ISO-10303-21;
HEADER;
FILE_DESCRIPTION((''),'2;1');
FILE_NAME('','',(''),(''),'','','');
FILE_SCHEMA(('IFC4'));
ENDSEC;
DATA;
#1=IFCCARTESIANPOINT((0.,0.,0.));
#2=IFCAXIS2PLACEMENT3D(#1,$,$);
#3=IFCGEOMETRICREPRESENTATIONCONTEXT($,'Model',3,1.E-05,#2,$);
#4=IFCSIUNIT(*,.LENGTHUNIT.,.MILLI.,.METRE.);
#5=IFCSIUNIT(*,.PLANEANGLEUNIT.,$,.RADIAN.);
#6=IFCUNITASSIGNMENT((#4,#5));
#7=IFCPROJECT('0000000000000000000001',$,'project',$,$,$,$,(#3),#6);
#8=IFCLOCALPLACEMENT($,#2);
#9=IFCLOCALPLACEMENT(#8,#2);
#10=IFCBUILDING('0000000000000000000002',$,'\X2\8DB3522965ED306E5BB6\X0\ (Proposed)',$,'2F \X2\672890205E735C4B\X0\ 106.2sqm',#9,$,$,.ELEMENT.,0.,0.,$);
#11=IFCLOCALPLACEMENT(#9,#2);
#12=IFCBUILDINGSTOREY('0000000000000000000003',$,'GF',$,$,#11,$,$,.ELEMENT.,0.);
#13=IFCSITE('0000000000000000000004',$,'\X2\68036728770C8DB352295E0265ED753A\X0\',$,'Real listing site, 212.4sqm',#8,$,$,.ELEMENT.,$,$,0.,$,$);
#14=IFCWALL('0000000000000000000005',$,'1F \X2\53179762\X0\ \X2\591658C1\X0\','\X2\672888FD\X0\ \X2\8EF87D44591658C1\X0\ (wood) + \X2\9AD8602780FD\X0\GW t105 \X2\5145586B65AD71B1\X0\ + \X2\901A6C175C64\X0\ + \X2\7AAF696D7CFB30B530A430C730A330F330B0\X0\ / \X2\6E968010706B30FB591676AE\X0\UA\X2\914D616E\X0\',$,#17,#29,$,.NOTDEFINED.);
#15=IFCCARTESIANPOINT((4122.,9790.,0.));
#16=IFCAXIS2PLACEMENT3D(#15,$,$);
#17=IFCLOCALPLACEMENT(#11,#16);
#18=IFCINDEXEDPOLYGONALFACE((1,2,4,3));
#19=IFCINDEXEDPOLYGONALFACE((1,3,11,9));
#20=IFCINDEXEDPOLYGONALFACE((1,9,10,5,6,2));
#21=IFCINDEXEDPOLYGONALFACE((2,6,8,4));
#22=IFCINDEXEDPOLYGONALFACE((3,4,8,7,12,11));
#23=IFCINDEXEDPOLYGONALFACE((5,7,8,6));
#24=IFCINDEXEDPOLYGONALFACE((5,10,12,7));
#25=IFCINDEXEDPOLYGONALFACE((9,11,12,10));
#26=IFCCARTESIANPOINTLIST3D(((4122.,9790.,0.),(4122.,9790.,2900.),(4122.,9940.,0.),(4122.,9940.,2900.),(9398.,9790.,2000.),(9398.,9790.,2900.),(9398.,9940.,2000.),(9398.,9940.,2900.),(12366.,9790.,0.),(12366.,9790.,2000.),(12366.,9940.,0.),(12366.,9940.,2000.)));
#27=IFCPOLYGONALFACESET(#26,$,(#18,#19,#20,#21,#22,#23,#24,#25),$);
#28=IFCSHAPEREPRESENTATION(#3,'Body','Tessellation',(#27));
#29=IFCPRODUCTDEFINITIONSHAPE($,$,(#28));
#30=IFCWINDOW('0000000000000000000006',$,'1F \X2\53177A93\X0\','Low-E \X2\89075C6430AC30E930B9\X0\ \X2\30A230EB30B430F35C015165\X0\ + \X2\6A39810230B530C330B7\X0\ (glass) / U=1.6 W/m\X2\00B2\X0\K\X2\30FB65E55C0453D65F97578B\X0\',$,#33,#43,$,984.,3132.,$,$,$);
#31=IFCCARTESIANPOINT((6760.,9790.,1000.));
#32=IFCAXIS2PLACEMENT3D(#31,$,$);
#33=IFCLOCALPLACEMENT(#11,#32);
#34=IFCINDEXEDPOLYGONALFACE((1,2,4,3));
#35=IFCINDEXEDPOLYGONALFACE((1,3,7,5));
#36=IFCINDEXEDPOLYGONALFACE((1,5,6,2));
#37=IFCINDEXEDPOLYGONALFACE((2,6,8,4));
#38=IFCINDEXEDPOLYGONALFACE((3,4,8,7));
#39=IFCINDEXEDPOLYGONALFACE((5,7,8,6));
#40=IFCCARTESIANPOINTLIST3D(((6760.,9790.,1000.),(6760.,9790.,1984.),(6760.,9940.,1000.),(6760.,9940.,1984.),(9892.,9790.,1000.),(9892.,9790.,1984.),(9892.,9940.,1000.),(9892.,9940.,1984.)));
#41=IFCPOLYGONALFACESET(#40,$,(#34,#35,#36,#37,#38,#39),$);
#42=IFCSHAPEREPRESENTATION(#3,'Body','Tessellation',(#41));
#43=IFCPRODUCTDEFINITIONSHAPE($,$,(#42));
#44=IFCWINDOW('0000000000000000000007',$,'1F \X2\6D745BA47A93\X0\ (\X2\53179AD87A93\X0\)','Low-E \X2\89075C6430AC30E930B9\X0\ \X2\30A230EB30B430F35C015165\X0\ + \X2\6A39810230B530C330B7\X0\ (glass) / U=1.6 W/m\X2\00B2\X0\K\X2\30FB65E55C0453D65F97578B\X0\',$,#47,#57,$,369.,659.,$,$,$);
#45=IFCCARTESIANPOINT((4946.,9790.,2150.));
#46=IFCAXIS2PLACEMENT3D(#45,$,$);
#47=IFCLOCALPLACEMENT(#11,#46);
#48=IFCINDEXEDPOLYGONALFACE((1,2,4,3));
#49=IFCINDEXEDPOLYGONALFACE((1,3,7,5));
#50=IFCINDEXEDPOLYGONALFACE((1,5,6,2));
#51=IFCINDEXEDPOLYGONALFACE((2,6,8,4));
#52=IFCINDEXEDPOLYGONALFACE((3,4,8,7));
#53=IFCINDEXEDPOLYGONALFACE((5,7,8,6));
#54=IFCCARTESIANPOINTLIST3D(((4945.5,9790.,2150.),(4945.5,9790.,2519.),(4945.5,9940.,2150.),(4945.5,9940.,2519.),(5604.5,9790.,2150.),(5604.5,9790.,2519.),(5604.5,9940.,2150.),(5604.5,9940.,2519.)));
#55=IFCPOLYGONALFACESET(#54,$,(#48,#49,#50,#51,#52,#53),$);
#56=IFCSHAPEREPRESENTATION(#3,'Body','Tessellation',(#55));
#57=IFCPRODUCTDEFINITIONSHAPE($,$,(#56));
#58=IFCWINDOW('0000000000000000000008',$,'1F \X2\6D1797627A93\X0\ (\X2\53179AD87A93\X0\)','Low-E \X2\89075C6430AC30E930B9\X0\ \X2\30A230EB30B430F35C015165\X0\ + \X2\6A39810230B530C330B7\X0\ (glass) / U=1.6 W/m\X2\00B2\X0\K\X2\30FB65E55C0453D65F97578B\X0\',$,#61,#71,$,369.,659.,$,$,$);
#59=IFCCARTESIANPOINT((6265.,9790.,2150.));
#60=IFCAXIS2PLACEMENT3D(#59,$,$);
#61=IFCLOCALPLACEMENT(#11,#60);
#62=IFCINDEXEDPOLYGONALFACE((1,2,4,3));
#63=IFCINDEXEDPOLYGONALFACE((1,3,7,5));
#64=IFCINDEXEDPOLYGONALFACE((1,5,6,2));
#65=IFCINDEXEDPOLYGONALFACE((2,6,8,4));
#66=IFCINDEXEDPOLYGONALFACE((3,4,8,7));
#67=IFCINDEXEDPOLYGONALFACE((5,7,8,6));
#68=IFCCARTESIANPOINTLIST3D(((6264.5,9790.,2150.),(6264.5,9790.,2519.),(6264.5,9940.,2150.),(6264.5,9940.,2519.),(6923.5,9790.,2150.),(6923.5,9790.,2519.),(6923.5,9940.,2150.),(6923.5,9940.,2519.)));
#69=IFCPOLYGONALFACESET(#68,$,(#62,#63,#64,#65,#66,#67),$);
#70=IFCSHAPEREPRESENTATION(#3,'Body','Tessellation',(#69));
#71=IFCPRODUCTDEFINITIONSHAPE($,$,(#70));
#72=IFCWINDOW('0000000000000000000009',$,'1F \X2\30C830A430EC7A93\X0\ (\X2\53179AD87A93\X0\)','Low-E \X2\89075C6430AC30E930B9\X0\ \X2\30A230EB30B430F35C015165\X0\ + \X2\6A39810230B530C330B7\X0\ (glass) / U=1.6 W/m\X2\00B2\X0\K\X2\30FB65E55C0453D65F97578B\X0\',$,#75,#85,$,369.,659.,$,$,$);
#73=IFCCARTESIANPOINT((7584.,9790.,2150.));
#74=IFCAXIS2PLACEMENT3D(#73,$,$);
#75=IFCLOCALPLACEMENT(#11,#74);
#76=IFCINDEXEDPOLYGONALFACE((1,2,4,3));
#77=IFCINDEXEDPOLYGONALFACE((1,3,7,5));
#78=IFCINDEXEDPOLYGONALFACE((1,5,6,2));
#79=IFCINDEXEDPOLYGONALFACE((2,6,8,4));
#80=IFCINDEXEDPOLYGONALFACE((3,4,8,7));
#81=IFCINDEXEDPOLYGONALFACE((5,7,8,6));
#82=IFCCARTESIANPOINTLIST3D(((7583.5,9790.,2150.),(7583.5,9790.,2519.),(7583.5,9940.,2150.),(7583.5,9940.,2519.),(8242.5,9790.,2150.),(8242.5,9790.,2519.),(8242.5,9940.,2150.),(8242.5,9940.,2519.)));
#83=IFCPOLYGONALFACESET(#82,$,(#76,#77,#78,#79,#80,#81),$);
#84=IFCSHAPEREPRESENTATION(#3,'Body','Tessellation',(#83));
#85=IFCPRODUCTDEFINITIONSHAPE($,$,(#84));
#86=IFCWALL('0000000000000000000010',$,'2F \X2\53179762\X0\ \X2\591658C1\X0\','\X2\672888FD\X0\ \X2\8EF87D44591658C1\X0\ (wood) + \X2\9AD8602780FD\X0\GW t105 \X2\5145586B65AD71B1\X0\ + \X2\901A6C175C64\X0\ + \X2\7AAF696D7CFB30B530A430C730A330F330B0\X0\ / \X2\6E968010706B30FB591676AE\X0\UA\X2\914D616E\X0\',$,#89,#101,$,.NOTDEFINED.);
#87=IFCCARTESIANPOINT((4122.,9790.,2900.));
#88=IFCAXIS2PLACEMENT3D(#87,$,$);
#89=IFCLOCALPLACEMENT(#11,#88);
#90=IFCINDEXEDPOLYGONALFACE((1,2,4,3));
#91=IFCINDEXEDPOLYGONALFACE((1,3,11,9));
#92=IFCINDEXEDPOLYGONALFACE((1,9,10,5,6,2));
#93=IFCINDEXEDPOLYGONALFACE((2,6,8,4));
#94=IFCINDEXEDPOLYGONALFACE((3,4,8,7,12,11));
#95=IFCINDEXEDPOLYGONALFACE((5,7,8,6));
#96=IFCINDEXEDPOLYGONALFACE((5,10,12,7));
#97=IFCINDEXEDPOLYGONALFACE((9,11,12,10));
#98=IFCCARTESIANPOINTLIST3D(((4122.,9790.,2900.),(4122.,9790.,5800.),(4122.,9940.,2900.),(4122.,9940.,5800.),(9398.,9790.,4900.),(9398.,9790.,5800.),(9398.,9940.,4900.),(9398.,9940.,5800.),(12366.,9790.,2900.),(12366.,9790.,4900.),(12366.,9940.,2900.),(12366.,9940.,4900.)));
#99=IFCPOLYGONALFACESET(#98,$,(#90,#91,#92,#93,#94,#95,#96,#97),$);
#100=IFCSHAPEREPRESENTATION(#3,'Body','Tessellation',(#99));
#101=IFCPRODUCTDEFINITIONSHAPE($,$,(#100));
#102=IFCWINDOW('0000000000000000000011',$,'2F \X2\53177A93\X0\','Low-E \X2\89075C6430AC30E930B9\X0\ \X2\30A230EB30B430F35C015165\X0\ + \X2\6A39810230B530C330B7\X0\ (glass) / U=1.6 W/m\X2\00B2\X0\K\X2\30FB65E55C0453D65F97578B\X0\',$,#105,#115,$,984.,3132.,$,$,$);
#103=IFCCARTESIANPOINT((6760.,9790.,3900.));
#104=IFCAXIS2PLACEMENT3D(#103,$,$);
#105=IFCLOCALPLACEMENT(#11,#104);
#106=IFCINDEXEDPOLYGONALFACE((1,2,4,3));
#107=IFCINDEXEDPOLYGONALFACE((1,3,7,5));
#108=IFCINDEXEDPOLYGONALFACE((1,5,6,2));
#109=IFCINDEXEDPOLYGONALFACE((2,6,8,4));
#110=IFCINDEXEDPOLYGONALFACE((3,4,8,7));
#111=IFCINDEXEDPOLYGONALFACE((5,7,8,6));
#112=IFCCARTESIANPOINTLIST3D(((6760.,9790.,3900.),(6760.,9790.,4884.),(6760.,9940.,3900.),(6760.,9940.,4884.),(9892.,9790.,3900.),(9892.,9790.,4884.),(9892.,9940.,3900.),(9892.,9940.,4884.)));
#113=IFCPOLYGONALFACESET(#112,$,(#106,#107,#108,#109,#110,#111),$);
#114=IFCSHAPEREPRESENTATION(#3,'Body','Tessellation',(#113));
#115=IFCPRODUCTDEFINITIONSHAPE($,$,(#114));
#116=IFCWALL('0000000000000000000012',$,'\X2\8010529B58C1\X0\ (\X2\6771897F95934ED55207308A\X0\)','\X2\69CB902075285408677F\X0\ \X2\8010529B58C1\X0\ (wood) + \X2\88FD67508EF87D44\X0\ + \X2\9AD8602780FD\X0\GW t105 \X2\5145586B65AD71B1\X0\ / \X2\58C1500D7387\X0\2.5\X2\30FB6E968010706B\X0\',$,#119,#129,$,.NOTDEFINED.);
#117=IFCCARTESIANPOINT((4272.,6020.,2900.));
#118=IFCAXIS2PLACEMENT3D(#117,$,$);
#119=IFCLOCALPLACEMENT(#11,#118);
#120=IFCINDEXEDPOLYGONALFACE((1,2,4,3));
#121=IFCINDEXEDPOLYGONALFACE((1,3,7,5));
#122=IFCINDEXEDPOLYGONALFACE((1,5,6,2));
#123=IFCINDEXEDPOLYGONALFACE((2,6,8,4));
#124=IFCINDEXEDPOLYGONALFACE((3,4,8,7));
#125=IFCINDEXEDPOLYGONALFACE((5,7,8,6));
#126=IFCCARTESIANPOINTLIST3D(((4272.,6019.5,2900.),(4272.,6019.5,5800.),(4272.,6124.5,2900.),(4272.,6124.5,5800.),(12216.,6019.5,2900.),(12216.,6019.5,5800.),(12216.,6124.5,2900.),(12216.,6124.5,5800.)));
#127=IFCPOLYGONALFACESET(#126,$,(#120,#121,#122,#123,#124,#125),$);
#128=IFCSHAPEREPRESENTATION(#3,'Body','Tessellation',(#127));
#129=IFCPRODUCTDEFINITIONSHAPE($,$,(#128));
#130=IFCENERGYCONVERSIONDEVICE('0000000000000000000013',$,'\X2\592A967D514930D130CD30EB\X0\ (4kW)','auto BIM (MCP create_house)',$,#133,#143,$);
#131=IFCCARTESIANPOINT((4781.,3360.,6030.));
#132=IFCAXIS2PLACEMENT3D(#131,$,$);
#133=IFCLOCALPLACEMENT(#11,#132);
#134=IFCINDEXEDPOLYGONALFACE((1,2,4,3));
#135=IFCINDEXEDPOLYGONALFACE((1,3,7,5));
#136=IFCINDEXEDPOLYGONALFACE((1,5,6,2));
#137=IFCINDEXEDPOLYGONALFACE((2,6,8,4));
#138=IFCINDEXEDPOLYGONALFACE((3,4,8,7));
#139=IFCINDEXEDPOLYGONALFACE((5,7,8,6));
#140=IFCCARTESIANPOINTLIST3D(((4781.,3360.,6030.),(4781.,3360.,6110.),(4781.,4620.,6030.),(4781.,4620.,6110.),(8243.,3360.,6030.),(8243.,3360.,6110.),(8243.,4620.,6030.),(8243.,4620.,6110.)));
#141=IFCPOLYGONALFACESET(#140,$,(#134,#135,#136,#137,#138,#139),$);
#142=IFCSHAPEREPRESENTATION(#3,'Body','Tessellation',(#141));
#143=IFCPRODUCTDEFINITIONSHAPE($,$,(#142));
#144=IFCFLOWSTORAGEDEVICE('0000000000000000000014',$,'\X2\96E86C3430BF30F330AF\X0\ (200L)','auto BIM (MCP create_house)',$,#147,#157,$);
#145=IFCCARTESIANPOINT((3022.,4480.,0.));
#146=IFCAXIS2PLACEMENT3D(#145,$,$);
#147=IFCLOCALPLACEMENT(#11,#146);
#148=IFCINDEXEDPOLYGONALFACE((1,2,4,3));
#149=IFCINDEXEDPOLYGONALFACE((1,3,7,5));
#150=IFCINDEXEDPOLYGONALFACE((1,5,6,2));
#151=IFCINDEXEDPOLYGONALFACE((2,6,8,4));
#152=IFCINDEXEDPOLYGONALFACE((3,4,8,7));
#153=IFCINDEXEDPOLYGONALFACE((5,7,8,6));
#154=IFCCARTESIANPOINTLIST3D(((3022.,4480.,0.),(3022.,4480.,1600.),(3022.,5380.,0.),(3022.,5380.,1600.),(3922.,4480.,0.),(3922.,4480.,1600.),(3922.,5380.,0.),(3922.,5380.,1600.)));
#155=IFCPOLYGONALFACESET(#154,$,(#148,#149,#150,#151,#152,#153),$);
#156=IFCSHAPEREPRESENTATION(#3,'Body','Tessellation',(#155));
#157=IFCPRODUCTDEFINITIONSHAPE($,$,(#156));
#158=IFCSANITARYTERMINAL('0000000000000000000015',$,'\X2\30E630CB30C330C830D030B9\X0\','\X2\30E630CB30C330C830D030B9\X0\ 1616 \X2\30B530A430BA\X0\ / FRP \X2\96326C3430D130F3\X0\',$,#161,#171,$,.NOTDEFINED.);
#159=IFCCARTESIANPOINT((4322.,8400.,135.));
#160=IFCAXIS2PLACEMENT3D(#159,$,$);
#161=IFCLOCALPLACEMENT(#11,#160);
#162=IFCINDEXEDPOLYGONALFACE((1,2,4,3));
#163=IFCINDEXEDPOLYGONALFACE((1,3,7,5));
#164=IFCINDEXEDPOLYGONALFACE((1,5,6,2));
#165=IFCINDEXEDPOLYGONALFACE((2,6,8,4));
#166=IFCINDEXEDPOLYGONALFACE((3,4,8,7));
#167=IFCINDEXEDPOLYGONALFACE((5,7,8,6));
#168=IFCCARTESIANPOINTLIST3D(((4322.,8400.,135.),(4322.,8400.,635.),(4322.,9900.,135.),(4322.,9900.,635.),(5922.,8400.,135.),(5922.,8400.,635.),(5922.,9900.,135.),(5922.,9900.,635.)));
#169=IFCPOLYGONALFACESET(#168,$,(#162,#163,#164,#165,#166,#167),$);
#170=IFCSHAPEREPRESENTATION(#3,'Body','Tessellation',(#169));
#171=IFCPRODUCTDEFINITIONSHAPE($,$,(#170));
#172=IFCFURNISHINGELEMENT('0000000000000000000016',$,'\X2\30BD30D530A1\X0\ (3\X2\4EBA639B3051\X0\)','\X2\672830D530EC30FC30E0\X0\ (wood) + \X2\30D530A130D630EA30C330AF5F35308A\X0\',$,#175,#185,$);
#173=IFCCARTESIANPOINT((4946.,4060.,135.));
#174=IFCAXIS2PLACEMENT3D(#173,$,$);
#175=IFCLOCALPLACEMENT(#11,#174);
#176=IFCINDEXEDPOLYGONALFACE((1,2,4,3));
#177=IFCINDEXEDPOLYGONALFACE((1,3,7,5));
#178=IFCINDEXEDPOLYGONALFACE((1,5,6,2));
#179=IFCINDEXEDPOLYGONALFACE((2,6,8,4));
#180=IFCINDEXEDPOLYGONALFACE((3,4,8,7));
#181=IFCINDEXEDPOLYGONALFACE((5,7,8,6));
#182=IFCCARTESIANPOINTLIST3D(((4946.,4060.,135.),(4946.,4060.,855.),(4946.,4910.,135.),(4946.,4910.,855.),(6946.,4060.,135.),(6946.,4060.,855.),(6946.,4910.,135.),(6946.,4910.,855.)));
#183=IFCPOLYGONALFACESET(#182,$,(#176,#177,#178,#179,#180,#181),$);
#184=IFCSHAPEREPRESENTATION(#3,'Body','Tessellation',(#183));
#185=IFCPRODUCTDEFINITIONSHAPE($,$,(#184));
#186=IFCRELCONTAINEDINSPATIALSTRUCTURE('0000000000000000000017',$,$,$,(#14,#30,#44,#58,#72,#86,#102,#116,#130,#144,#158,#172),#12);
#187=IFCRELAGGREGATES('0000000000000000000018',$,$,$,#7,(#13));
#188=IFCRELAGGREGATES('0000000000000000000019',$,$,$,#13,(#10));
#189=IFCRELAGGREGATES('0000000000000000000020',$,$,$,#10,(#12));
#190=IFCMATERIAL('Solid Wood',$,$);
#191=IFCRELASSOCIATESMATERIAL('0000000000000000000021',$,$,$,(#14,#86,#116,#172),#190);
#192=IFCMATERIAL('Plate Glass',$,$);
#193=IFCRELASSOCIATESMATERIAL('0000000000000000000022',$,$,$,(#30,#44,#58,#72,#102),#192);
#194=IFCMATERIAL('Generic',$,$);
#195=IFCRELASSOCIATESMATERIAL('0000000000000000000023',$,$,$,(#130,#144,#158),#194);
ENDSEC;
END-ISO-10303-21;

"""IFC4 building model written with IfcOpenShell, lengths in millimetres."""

from ifc_helpers import new_model, si_unit, frame, frame_2d, origin, place, context, project, spatial, rectangle, extrude, material, element, fill, save


model = new_model("IFC4")

# Units and contexts
model_context = context("Model", 3, precision=1e-05, world=origin())
ifc_project = project(units=[si_unit("LENGTHUNIT", "METRE", prefix="MILLI"), si_unit("PLANEANGLEUNIT", "RADIAN")], contexts=[model_context])

# Site, building, storey
site_placement = place(None, origin())
site = spatial("IfcSite", under=ifc_project, at=site_placement, Name="栃木県足利市旭町", ObjectType="Real listing site, 212.4sqm", CompositionType="ELEMENT", RefElevation=0.0)
building_placement = place(site_placement, origin())
building = spatial("IfcBuilding", under=site, at=building_placement, Name="足利旭の家 (Proposed)", ObjectType="2F 木造平屋 106.2sqm", CompositionType="ELEMENT", ElevationOfRefHeight=0.0, ElevationOfTerrain=0.0)
storey_placement = place(building_placement, origin())
storey = spatial("IfcBuildingStorey", under=building, at=storey_placement, Name="GF", CompositionType="ELEMENT", Elevation=0.0)

# Wall, openings, windows
ifc_material_1 = material(Name="Solid Wood")
wall_1_placement = place(storey_placement, frame((4122.0, 9790.0, 0.0)))
wall_1 = element("IfcWall", 1, at=wall_1_placement, inside=storey, material=ifc_material_1, Name="1F 北面 外壁", Description="木製 軸組外壁 (wood) + 高性能GW t105 充填断熱 + 通気層 + 窯業系サイディング / 準耐火・外皮UA配慮", PredefinedType="NOTDEFINED", context=model_context, shape_type="SweptSolid", body=[
    extrude(rectangle(XDim=8244.0, YDim=150.0, at=frame_2d((4122.0, 75.0))), frame((4122.0, 9790.0, 0.0)), (0.0, 0.0, 1.0), 2900.0),
])
opening_1_placement = place(storey_placement, frame((6760.0, 9790.0, 1000.0)))
opening_1 = element("IfcOpeningElement", 2, at=opening_1_placement, cuts=wall_1, PredefinedType="NOTDEFINED", context=model_context, shape_type="SweptSolid", body=[
    extrude(rectangle(XDim=3132.0, YDim=150.0, at=frame_2d((1566.0, 75.0))), frame((6760.0, 9790.0, 1000.0)), (0.0, 0.0, 1.0), 984.0),
])
opening_2_placement = place(storey_placement, frame((4946.0, 9790.0, 2150.0)))
opening_2 = element("IfcOpeningElement", 3, at=opening_2_placement, cuts=wall_1, PredefinedType="NOTDEFINED", context=model_context, shape_type="SweptSolid", body=[
    extrude(rectangle(XDim=659.0, YDim=150.0, at=frame_2d((329.0, 75.0))), frame((4946.0, 9790.0, 2150.0)), (0.0, 0.0, 1.0), 369.0),
])
opening_3_placement = place(storey_placement, frame((6265.0, 9790.0, 2150.0)))
opening_3 = element("IfcOpeningElement", 4, at=opening_3_placement, cuts=wall_1, PredefinedType="NOTDEFINED", context=model_context, shape_type="SweptSolid", body=[
    extrude(rectangle(XDim=659.0, YDim=150.0, at=frame_2d((329.0, 75.0))), frame((6265.0, 9790.0, 2150.0)), (0.0, 0.0, 1.0), 369.0),
])
opening_4_placement = place(storey_placement, frame((7584.0, 9790.0, 2150.0)))
opening_4 = element("IfcOpeningElement", 5, at=opening_4_placement, cuts=wall_1, PredefinedType="NOTDEFINED", context=model_context, shape_type="SweptSolid", body=[
    extrude(rectangle(XDim=659.0, YDim=150.0, at=frame_2d((329.0, 75.0))), frame((7584.0, 9790.0, 2150.0)), (0.0, 0.0, 1.0), 369.0),
])
ifc_material_2 = material(Name="Plate Glass")
window_1_placement = place(storey_placement, frame((6760.0, 9790.0, 1000.0)))
window_1 = element("IfcWindow", 6, at=window_1_placement, inside=storey, material=ifc_material_2, Name="1F 北窓", Description="Low-E 複層ガラス アルゴン封入 + 樹脂サッシ (glass) / U=1.6 W/m²K・日射取得型", OverallHeight=984.0, OverallWidth=3132.0, context=model_context, shape_type="SweptSolid", body=[
    extrude(rectangle(XDim=3132.0, YDim=150.0, at=frame_2d((1566.0, 75.0))), frame((6760.0, 9790.0, 1000.0)), (0.0, 0.0, 1.0), 984.0),
])
fill(opening_1, window_1)
window_2_placement = place(storey_placement, frame((4946.0, 9790.0, 2150.0)))
window_2 = element("IfcWindow", 7, at=window_2_placement, inside=storey, material=ifc_material_2, Name="1F 浴室窓 (北高窓)", Description="Low-E 複層ガラス アルゴン封入 + 樹脂サッシ (glass) / U=1.6 W/m²K・日射取得型", OverallHeight=369.0, OverallWidth=659.0, context=model_context, shape_type="SweptSolid", body=[
    extrude(rectangle(XDim=659.0, YDim=150.0, at=frame_2d((329.0, 75.0))), frame((4946.0, 9790.0, 2150.0)), (0.0, 0.0, 1.0), 369.0),
])
fill(opening_2, window_2)
window_3_placement = place(storey_placement, frame((6265.0, 9790.0, 2150.0)))
window_3 = element("IfcWindow", 8, at=window_3_placement, inside=storey, material=ifc_material_2, Name="1F 洗面窓 (北高窓)", Description="Low-E 複層ガラス アルゴン封入 + 樹脂サッシ (glass) / U=1.6 W/m²K・日射取得型", OverallHeight=369.0, OverallWidth=659.0, context=model_context, shape_type="SweptSolid", body=[
    extrude(rectangle(XDim=659.0, YDim=150.0, at=frame_2d((329.0, 75.0))), frame((6265.0, 9790.0, 2150.0)), (0.0, 0.0, 1.0), 369.0),
])
fill(opening_3, window_3)
window_4_placement = place(storey_placement, frame((7584.0, 9790.0, 2150.0)))
window_4 = element("IfcWindow", 9, at=window_4_placement, inside=storey, material=ifc_material_2, Name="1F トイレ窓 (北高窓)", Description="Low-E 複層ガラス アルゴン封入 + 樹脂サッシ (glass) / U=1.6 W/m²K・日射取得型", OverallHeight=369.0, OverallWidth=659.0, context=model_context, shape_type="SweptSolid", body=[
    extrude(rectangle(XDim=659.0, YDim=150.0, at=frame_2d((329.0, 75.0))), frame((7584.0, 9790.0, 2150.0)), (0.0, 0.0, 1.0), 369.0),
])
fill(opening_4, window_4)

# Wall, opening, window
wall_2_placement = place(storey_placement, frame((4122.0, 9790.0, 2900.0)))
wall_2 = element("IfcWall", 10, at=wall_2_placement, inside=storey, material=ifc_material_1, Name="2F 北面 外壁", Description="木製 軸組外壁 (wood) + 高性能GW t105 充填断熱 + 通気層 + 窯業系サイディング / 準耐火・外皮UA配慮", PredefinedType="NOTDEFINED", context=model_context, shape_type="SweptSolid", body=[
    extrude(rectangle(XDim=8244.0, YDim=150.0, at=frame_2d((4122.0, 75.0))), frame((4122.0, 9790.0, 2900.0)), (0.0, 0.0, 1.0), 2900.0),
])
opening_5_placement = place(storey_placement, frame((6760.0, 9790.0, 3900.0)))
opening_5 = element("IfcOpeningElement", 11, at=opening_5_placement, cuts=wall_2, PredefinedType="NOTDEFINED", context=model_context, shape_type="SweptSolid", body=[
    extrude(rectangle(XDim=3132.0, YDim=150.0, at=frame_2d((1566.0, 75.0))), frame((6760.0, 9790.0, 3900.0)), (0.0, 0.0, 1.0), 984.0),
])
window_5_placement = place(storey_placement, frame((6760.0, 9790.0, 3900.0)))
window_5 = element("IfcWindow", 12, at=window_5_placement, inside=storey, material=ifc_material_2, Name="2F 北窓", Description="Low-E 複層ガラス アルゴン封入 + 樹脂サッシ (glass) / U=1.6 W/m²K・日射取得型", OverallHeight=984.0, OverallWidth=3132.0, context=model_context, shape_type="SweptSolid", body=[
    extrude(rectangle(XDim=3132.0, YDim=150.0, at=frame_2d((1566.0, 75.0))), frame((6760.0, 9790.0, 3900.0)), (0.0, 0.0, 1.0), 984.0),
])
fill(opening_5, window_5)

# Wall
wall_3_placement = place(storey_placement, frame((4272.0, 6020.0, 2900.0)))
element("IfcWall", 13, at=wall_3_placement, inside=storey, material=ifc_material_1, Name="耐力壁 (東西間仕切り)", Description="構造用合板 耐力壁 (wood) + 製材軸組 + 高性能GW t105 充填断熱 / 壁倍率2.5・準耐火", PredefinedType="NOTDEFINED", context=model_context, shape_type="SweptSolid", body=[
    extrude(rectangle(XDim=7944.0, YDim=105.0, at=frame_2d((3972.0, 52.0))), frame((4272.0, 6020.0, 2900.0)), (0.0, 0.0, 1.0), 2900.0),
])

# Energy conversion device
ifc_material_3 = material(Name="Generic")
energy_conversion_device_placement = place(storey_placement, frame((4781.0, 3360.0, 6030.0)))
element("IfcEnergyConversionDevice", 14, at=energy_conversion_device_placement, inside=storey, material=ifc_material_3, Name="太陽光パネル (4kW)", Description="auto BIM (MCP create_house)", context=model_context, shape_type="SweptSolid", body=[
    extrude(rectangle(XDim=3462.0, YDim=1260.0, at=frame_2d((1731.0, 630.0))), frame((4781.0, 3360.0, 6030.0)), (0.0, 0.0, 1.0), 80.0),
])

# Flow storage device
flow_storage_device_placement = place(storey_placement, frame((3022.0, 4480.0, 0.0)))
element("IfcFlowStorageDevice", 15, at=flow_storage_device_placement, inside=storey, material=ifc_material_3, Name="雨水タンク (200L)", Description="auto BIM (MCP create_house)", context=model_context, shape_type="SweptSolid", body=[
    extrude(rectangle(XDim=900.0, YDim=900.0, at=frame_2d((450.0, 450.0))), frame((3022.0, 4480.0, 0.0)), (0.0, 0.0, 1.0), 1600.0),
])

# Sanitary terminal
sanitary_terminal_placement = place(storey_placement, frame((4322.0, 8400.0, 135.0)))
element("IfcSanitaryTerminal", 16, at=sanitary_terminal_placement, inside=storey, material=ifc_material_3, Name="ユニットバス", Description="ユニットバス 1616 サイズ / FRP 防水パン", PredefinedType="NOTDEFINED", context=model_context, shape_type="SweptSolid", body=[
    extrude(rectangle(XDim=1600.0, YDim=1500.0, at=frame_2d((800.0, 750.0))), frame((4322.0, 8400.0, 135.0)), (0.0, 0.0, 1.0), 500.0),
])

# Furnishing element
furnishing_1_placement = place(storey_placement, frame((4946.0, 4060.0, 135.0)))
element("IfcFurnishingElement", 17, at=furnishing_1_placement, inside=storey, material=ifc_material_1, Name="ソファ (3人掛け)", Description="木フレーム (wood) + ファブリック張り", context=model_context, shape_type="SweptSolid", body=[
    extrude(rectangle(XDim=2000.0, YDim=850.0, at=frame_2d((1000.0, 425.0))), frame((4946.0, 4060.0, 135.0)), (0.0, 0.0, 1.0), 720.0),
])

save(model, "model.ifc")
